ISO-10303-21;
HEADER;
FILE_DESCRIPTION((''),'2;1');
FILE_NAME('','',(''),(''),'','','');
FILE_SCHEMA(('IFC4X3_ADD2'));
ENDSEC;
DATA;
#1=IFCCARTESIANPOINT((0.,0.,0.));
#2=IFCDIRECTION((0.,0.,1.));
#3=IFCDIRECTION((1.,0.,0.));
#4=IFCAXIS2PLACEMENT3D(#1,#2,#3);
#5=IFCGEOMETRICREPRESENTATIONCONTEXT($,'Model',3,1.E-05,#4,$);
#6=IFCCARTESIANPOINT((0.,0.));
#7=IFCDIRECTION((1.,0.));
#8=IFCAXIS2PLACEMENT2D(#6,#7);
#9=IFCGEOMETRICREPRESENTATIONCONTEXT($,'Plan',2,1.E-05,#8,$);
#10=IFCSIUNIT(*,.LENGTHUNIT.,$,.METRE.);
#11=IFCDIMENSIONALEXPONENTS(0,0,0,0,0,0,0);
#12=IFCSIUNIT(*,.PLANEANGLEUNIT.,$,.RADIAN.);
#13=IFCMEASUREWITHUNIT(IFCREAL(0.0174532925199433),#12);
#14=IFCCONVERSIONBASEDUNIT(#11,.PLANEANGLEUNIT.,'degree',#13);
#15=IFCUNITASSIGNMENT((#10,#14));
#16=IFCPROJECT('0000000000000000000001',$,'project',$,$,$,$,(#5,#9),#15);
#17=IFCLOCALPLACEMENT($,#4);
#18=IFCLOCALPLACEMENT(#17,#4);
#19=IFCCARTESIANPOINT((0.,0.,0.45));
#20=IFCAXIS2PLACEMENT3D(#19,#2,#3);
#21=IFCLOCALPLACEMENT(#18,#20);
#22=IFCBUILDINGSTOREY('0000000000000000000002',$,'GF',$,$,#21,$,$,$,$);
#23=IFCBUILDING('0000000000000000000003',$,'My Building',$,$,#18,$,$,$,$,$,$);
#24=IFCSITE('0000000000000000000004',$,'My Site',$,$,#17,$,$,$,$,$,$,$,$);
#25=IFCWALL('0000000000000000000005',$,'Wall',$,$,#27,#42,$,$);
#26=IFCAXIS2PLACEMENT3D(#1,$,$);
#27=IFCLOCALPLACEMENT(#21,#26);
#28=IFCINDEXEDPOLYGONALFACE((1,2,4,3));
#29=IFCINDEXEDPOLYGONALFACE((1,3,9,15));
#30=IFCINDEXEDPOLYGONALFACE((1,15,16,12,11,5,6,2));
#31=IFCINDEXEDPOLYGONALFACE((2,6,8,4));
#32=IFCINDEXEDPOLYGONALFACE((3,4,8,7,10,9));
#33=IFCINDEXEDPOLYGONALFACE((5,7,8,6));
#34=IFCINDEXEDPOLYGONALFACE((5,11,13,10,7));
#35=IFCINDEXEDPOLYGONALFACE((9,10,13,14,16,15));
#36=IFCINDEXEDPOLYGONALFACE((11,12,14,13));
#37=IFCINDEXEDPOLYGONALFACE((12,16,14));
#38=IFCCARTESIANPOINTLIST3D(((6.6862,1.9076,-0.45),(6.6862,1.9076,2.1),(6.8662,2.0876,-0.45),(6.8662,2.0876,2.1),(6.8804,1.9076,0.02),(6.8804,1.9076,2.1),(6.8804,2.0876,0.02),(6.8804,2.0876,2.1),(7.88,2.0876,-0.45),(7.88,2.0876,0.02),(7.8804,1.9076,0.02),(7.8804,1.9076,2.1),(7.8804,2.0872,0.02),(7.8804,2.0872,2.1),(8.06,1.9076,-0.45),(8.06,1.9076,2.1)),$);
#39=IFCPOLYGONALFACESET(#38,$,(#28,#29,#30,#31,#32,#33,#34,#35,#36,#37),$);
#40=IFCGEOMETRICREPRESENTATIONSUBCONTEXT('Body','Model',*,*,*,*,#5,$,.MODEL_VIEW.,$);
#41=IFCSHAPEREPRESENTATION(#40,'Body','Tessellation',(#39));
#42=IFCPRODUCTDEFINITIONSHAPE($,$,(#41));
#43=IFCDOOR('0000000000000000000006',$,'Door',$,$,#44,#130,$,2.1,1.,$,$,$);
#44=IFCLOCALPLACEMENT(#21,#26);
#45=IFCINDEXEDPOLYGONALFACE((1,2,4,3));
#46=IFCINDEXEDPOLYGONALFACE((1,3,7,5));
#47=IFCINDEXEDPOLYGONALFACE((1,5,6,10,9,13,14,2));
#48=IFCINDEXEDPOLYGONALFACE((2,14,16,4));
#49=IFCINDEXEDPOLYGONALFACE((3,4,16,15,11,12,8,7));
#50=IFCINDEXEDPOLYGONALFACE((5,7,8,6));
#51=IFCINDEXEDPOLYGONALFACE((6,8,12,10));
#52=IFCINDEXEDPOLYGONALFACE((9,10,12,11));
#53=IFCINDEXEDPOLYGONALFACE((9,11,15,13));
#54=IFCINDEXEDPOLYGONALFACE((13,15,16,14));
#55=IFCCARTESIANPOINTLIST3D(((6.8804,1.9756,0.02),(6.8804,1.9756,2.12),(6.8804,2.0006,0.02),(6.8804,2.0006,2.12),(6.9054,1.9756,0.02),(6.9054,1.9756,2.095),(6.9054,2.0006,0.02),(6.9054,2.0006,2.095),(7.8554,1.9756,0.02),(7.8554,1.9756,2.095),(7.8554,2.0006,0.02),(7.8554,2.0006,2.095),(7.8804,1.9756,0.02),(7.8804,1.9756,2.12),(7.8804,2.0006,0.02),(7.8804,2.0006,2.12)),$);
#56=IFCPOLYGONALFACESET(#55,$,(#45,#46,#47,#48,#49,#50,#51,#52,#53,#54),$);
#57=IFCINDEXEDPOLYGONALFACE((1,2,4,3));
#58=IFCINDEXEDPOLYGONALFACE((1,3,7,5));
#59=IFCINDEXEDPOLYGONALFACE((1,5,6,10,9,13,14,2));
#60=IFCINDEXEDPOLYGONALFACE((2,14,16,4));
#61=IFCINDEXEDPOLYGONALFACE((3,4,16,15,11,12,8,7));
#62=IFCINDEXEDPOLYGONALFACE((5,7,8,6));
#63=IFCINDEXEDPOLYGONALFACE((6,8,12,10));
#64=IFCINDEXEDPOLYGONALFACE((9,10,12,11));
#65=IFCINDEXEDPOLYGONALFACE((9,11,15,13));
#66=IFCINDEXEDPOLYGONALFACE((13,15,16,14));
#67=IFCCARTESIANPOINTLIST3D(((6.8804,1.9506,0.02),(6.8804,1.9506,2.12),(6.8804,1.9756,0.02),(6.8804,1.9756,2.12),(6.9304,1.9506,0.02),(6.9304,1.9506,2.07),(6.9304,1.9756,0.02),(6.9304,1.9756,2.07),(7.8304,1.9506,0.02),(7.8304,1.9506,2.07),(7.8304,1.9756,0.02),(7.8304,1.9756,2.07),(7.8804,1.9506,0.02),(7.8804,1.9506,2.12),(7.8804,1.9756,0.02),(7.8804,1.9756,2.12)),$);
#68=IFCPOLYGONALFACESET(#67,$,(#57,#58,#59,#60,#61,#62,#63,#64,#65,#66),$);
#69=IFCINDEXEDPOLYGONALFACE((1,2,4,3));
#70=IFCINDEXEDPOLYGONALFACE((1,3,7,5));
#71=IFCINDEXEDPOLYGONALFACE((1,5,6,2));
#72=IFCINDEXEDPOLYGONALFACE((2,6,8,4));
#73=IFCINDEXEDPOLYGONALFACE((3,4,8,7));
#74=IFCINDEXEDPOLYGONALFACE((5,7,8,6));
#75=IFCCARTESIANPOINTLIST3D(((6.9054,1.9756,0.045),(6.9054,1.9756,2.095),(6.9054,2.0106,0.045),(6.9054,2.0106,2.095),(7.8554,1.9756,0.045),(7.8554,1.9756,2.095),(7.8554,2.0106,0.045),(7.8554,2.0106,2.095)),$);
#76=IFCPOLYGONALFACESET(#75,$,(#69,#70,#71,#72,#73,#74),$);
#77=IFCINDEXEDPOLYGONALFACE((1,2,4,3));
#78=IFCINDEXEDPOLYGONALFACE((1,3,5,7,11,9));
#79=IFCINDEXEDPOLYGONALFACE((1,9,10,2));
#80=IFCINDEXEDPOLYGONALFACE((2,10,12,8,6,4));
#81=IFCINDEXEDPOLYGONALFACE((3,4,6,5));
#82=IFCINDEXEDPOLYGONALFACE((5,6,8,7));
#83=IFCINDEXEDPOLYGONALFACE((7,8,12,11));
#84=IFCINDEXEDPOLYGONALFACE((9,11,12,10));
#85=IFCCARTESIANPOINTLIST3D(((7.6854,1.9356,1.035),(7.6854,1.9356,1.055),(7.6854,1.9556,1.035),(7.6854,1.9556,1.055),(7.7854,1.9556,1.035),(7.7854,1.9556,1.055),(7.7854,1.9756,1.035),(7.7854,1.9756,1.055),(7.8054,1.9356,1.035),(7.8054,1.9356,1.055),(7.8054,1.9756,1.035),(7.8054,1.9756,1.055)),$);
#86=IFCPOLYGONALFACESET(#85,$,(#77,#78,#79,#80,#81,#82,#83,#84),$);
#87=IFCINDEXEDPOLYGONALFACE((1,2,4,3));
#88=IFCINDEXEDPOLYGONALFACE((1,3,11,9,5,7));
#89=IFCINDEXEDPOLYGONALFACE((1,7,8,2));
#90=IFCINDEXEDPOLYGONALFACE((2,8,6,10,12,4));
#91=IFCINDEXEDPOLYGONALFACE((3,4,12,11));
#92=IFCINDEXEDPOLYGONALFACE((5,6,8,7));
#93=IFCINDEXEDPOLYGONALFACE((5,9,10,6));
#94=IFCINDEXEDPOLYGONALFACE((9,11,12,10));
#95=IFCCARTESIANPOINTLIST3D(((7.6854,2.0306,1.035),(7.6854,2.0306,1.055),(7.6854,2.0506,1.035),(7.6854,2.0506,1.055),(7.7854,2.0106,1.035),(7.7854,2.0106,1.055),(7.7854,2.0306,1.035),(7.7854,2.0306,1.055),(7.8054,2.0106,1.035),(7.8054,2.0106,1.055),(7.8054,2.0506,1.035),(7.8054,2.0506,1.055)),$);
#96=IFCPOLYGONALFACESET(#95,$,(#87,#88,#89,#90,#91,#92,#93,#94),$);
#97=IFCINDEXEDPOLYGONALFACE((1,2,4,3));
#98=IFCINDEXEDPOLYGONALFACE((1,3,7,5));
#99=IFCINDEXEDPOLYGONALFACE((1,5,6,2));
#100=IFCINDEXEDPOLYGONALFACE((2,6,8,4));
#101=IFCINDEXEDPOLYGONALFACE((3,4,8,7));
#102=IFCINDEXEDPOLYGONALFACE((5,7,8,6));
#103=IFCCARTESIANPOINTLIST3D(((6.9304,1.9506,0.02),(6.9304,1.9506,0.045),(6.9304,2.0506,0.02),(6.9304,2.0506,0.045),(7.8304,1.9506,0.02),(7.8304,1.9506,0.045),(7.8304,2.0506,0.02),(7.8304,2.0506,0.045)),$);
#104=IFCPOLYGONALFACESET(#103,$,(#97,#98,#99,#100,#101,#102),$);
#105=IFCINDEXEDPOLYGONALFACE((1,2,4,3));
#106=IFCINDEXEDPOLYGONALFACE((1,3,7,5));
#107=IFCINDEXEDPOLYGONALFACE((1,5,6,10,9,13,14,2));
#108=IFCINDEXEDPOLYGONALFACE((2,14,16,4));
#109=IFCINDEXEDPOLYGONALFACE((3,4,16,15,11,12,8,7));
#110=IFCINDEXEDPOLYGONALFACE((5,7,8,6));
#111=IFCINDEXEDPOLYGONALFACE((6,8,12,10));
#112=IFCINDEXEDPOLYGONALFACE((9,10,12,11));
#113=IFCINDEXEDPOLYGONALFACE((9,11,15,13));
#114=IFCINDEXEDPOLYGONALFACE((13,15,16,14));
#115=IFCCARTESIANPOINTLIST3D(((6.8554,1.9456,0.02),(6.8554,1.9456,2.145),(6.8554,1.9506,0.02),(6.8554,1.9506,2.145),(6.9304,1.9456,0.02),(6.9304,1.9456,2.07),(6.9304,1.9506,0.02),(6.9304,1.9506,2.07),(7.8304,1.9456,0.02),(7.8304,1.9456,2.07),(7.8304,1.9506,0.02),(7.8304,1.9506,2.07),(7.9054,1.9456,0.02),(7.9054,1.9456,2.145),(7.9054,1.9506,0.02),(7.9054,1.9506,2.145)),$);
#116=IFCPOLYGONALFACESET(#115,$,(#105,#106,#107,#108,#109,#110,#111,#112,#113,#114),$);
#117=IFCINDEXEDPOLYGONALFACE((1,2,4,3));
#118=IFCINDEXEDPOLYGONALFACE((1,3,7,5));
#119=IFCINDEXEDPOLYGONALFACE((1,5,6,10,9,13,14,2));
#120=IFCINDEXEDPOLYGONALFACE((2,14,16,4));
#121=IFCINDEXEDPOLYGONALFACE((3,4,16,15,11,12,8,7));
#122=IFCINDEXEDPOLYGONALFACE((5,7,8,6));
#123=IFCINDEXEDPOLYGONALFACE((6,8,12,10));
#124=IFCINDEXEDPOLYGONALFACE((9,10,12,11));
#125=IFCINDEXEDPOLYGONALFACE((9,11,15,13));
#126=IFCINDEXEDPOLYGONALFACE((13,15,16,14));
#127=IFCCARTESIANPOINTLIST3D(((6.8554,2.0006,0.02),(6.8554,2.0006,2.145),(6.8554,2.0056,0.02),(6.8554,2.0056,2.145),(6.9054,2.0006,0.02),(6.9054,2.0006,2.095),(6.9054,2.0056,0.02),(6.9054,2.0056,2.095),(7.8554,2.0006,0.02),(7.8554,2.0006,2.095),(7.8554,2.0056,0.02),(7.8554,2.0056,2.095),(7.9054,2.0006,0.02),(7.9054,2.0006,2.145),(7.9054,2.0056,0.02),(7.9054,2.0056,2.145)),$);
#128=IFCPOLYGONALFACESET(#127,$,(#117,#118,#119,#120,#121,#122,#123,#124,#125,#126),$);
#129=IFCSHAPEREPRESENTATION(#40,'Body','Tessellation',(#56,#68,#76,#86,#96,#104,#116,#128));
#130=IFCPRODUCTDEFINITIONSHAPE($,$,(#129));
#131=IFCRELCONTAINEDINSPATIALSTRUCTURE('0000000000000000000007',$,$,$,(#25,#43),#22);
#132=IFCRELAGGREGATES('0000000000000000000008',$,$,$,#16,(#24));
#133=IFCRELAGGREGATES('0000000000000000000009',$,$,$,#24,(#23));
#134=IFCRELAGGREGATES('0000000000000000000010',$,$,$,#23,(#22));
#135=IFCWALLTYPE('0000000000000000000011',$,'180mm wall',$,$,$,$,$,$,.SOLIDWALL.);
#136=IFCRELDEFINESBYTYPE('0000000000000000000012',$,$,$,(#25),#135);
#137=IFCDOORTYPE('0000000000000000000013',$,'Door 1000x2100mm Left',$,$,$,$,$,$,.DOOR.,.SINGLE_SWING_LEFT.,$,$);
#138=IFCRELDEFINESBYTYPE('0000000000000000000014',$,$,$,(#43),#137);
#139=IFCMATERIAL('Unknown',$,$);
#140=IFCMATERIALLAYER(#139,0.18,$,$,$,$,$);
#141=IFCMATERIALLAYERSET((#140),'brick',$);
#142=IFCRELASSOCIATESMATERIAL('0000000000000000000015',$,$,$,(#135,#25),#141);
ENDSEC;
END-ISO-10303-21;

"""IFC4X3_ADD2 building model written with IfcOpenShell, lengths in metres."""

from ifc_helpers import new_model, entity, si_unit, converted_unit, frame, origin_with_axes, origin_2d_with_axis, place, context, subcontext, project, spatial, line, indexed_curve, outline, extrude, shape, source, transform, mapped, material, layer, layer_set, layer_usage, type_object, type_shapes, element, fill, save


model = new_model("IFC4X3_ADD2")

# Units and contexts
model_context = context("Model", 3, precision=1e-05, world=origin_with_axes())
plan_context = context("Plan", 2, precision=1e-05, world=origin_2d_with_axis())
body_context_1 = subcontext(model_context, "Body", "Model", "MODEL_VIEW")
body_context_2 = subcontext(plan_context, "Body", "Plan", "PLAN_VIEW")
ifc_project = project(units=[si_unit("LENGTHUNIT", "METRE"), converted_unit("PLANEANGLEUNIT", "degree", entity("IfcReal", 0.0174532925199433), si_unit("PLANEANGLEUNIT", "RADIAN"), dimensions=[0, 0, 0, 0, 0, 0, 0])], contexts=[model_context, plan_context])

# Site, building, storey
site_placement = place(None, origin_with_axes())
site = spatial("IfcSite", under=ifc_project, at=site_placement, Name="My Site")
building_placement = place(site_placement, origin_with_axes())
building = spatial("IfcBuilding", under=site, at=building_placement, Name="My Building")
storey_placement = place(building_placement, frame((0.0, 0.0, 0.45), z_axis=(0.0, 0.0, 1.0), x_axis=(1.0, 0.0, 0.0)))
storey = spatial("IfcBuildingStorey", under=building, at=storey_placement, Name="GF")

# Shared definitions
ifc_material_1 = material(Name="Unknown")
ifc_layer_1 = layer(ifc_material_1, 0.18)
ifc_layer_set_1 = layer_set([ifc_layer_1], Name="brick")
wall_type = type_object("IfcWallType", Name="180mm wall", PredefinedType="SOLIDWALL", material=ifc_layer_set_1)

# Wall, opening, door
ifc_layer_usage_1 = layer_usage(ifc_layer_set_1, "AXIS2", "POSITIVE", 0.0)
wall_1_placement = place(storey_placement, frame((8.06, 2.0876, -0.45), z_axis=(0.0, 0.0, 1.0), x_axis=(-1.0, 0.0, 0.0)))
wall_1 = element("IfcWall", 1, at=wall_1_placement, inside=storey, type_object=wall_type, material=ifc_layer_usage_1, Name="Wall", context=body_context_1, shape_type="SweptSolid", body=[
    extrude(outline(indexed_curve([(0.18, 0.0), (0.0, 0.18), (1.3739, 0.18), (1.1939, 0.0)], segments=[line(1, 2, 3, 4, 1)])), origin_with_axes(), (0.0, 0.0, 1.0), 2.55),
])
shared_shape_1 = source(origin_with_axes(), body_context_1, "Body", "SweptSolid", [
    extrude(outline(indexed_curve([(0.0, 0.0), (1.0, 0.0), (1.0, 2.1), (0.0, 2.1)], segments=[line(1, 2, 3, 4, 1)])), frame((0.0, -0.6, 0.0), z_axis=(0.0, -1.0, 0.0), x_axis=(1.0, 0.0, 0.0)), (0.0, 0.0, -1.0), 1.2),
])
opening_placement = place(wall_1_placement, frame((1.1796, 0.137, 0.47), z_axis=(0.0, 0.0, 1.0), x_axis=(-1.0, 0.0, 0.0)))
opening = element("IfcOpeningElement", 2, at=opening_placement, cuts=wall_1, PredefinedType="OPENING", context=body_context_1, shape_type="MappedRepresentation", body=[
    mapped(shared_shape_1, transform((0.0, 0.0, 0.0), x_axis=(1.0, 0.0, 0.0), y_axis=(0.0, 1.0, 0.0), z_axis=(0.0, 0.0, 1.0), scale=1.0)),
])
door_type = type_object("IfcDoorType", Name="Door 1000x2100mm Left", OperationType="SINGLE_SWING_LEFT", PredefinedType="DOOR")
shared_shape_2 = source(origin_with_axes(), body_context_1, "Body", "SweptSolid", [
    extrude(outline(indexed_curve([(0.0, 0.0), (0.0, 2.1), (1.0, 2.1), (1.0, 0.0), (0.975, 0.0), (0.975, 2.075), (0.025, 2.075), (0.025, 0.0)], segments=[line(1, 2, 3, 4, 5, 6, 7, 8, 1)])), frame((0.0, 0.025, 0.0), z_axis=(0.0, -1.0, 0.0), x_axis=(1.0, 0.0, 0.0)), (0.0, 0.0, -1.0), 0.025),
    extrude(outline(indexed_curve([(0.0, 0.0), (0.0, 2.1), (1.0, 2.1), (1.0, 0.0), (0.95, 0.0), (0.95, 2.05), (0.05, 2.05), (0.05, 0.0)], segments=[line(1, 2, 3, 4, 5, 6, 7, 8, 1)])), frame((0.0, 0.0, 0.0), z_axis=(0.0, -1.0, 0.0), x_axis=(1.0, 0.0, 0.0)), (0.0, 0.0, -1.0), 0.025),
    extrude(outline(indexed_curve([(0.0, 0.0), (0.95, 0.0), (0.95, 0.035), (0.0, 0.035)], segments=[line(1, 2, 3, 4, 1)])), frame((0.025, 0.025, 0.025), z_axis=(0.0, 0.0, 1.0), x_axis=(1.0, 0.0, 0.0)), (0.0, 0.0, 1.0), 2.05),
    extrude(outline(indexed_curve([(0.0, 0.0), (0.0, -0.04), (-0.12, -0.04), (-0.12, -0.02), (-0.02, -0.02), (-0.02, 0.0)], segments=[line(1, 2, 3, 4, 5, 6, 1)])), frame((0.925, 0.025, 1.015), z_axis=(0.0, 0.0, 1.0), x_axis=(1.0, 0.0, 0.0)), (0.0, 0.0, 1.0), 0.02),
    extrude(outline(indexed_curve([(0.0, 0.0), (0.0, 0.04), (-0.12, 0.04), (-0.12, 0.02), (-0.02, 0.02), (-0.02, 0.0)], segments=[line(1, 2, 3, 4, 5, 6, 1)])), frame((0.925, 0.06, 1.015), z_axis=(0.0, 0.0, 1.0), x_axis=(1.0, 0.0, 0.0)), (0.0, 0.0, 1.0), 0.02),
    extrude(outline(indexed_curve([(0.0, 0.0), (0.9, 0.0), (0.9, 0.1), (0.0, 0.1)], segments=[line(1, 2, 3, 4, 1)])), frame((0.05, 0.0, 0.0), z_axis=(0.0, 0.0, 1.0), x_axis=(1.0, 0.0, 0.0)), (0.0, 0.0, 1.0), 0.025),
    extrude(outline(indexed_curve([(0.0, 0.0), (0.0, 2.125), (1.05, 2.125), (1.05, 0.0), (0.975, 0.0), (0.975, 2.05), (0.075, 2.05), (0.075, 0.0)], segments=[line(1, 2, 3, 4, 5, 6, 7, 8, 1)])), frame((-0.025, -0.005, 0.0), z_axis=(0.0, -1.0, 0.0), x_axis=(1.0, 0.0, 0.0)), (0.0, 0.0, -1.0), 0.005),
    extrude(outline(indexed_curve([(0.0, 0.0), (0.0, 2.125), (1.05, 2.125), (1.05, 0.0), (1.0, 0.0), (1.0, 2.075), (0.05, 2.075), (0.05, 0.0)], segments=[line(1, 2, 3, 4, 5, 6, 7, 8, 1)])), frame((-0.025, 0.05, 0.0), z_axis=(0.0, -1.0, 0.0), x_axis=(1.0, 0.0, 0.0)), (0.0, 0.0, -1.0), 0.005),
])
shared_shape_3 = source(origin_with_axes(), body_context_2, "Body", "Curve2D", [
    entity("IfcIndexedPolyCurve", entity("IfcCartesianPointList2D", [[0.0, 0.0], [0.0, 0.05], [0.025, 0.05], [0.025, 0.025], [0.05, 0.025], [0.05, 0.0]]), [entity("IfcLineIndex", [1, 2, 3, 4, 5, 6, 1])]),
    entity("IfcIndexedPolyCurve", entity("IfcCartesianPointList2D", [[1.0, 0.0], [1.0, 0.05], [0.975, 0.05], [0.975, 0.025], [0.95, 0.025], [0.95, 0.0]]), [entity("IfcLineIndex", [1, 2, 3, 4, 5, 6, 1])]),
    entity("IfcTrimmedCurve", entity("IfcEllipse", entity("IfcAxis2Placement2D", entity("IfcCartesianPoint", [0.06, 0.05]), entity("IfcDirection", [1.0, 0.0])), 0.915, 0.95), [entity("IfcCartesianPoint", [0.975, 0.05])], [entity("IfcCartesianPoint", [0.06, 1.0])], True, "CARTESIAN"),
    entity("IfcIndexedPolyCurve", entity("IfcCartesianPointList2D", [[0.025, 0.05], [0.06, 0.05], [0.06, 1.0], [0.025, 1.0]]), [entity("IfcLineIndex", [1, 2, 3, 4, 1])]),
])
type_shapes(door_type, [shared_shape_2, shared_shape_3])
door_placement = place(opening_placement, frame((0.0, 0.0, 0.0), z_axis=(0.0, 0.0, 1.0), x_axis=(1.0, 0.0, 0.0)))
door = element("IfcDoor", 3, at=door_placement, inside=storey, type_object=door_type, Name="Door", OverallHeight=2.1, OverallWidth=1.0, shapes=[
    shape(body_context_1, "Body", "MappedRepresentation", [mapped(shared_shape_2, transform((0.0, 0.0, 0.0), x_axis=(1.0, 0.0, 0.0), y_axis=(0.0, 1.0, 0.0), z_axis=(0.0, 0.0, 1.0), scale=1.0))]),
    shape(body_context_2, "Body", "MappedRepresentation", [mapped(shared_shape_3, transform((0.0, 0.0, 0.0), x_axis=(1.0, 0.0, 0.0), y_axis=(0.0, 1.0, 0.0), z_axis=(0.0, 0.0, 1.0), scale=1.0))]),
])
fill(opening, door)

save(model, "model.ifc")
